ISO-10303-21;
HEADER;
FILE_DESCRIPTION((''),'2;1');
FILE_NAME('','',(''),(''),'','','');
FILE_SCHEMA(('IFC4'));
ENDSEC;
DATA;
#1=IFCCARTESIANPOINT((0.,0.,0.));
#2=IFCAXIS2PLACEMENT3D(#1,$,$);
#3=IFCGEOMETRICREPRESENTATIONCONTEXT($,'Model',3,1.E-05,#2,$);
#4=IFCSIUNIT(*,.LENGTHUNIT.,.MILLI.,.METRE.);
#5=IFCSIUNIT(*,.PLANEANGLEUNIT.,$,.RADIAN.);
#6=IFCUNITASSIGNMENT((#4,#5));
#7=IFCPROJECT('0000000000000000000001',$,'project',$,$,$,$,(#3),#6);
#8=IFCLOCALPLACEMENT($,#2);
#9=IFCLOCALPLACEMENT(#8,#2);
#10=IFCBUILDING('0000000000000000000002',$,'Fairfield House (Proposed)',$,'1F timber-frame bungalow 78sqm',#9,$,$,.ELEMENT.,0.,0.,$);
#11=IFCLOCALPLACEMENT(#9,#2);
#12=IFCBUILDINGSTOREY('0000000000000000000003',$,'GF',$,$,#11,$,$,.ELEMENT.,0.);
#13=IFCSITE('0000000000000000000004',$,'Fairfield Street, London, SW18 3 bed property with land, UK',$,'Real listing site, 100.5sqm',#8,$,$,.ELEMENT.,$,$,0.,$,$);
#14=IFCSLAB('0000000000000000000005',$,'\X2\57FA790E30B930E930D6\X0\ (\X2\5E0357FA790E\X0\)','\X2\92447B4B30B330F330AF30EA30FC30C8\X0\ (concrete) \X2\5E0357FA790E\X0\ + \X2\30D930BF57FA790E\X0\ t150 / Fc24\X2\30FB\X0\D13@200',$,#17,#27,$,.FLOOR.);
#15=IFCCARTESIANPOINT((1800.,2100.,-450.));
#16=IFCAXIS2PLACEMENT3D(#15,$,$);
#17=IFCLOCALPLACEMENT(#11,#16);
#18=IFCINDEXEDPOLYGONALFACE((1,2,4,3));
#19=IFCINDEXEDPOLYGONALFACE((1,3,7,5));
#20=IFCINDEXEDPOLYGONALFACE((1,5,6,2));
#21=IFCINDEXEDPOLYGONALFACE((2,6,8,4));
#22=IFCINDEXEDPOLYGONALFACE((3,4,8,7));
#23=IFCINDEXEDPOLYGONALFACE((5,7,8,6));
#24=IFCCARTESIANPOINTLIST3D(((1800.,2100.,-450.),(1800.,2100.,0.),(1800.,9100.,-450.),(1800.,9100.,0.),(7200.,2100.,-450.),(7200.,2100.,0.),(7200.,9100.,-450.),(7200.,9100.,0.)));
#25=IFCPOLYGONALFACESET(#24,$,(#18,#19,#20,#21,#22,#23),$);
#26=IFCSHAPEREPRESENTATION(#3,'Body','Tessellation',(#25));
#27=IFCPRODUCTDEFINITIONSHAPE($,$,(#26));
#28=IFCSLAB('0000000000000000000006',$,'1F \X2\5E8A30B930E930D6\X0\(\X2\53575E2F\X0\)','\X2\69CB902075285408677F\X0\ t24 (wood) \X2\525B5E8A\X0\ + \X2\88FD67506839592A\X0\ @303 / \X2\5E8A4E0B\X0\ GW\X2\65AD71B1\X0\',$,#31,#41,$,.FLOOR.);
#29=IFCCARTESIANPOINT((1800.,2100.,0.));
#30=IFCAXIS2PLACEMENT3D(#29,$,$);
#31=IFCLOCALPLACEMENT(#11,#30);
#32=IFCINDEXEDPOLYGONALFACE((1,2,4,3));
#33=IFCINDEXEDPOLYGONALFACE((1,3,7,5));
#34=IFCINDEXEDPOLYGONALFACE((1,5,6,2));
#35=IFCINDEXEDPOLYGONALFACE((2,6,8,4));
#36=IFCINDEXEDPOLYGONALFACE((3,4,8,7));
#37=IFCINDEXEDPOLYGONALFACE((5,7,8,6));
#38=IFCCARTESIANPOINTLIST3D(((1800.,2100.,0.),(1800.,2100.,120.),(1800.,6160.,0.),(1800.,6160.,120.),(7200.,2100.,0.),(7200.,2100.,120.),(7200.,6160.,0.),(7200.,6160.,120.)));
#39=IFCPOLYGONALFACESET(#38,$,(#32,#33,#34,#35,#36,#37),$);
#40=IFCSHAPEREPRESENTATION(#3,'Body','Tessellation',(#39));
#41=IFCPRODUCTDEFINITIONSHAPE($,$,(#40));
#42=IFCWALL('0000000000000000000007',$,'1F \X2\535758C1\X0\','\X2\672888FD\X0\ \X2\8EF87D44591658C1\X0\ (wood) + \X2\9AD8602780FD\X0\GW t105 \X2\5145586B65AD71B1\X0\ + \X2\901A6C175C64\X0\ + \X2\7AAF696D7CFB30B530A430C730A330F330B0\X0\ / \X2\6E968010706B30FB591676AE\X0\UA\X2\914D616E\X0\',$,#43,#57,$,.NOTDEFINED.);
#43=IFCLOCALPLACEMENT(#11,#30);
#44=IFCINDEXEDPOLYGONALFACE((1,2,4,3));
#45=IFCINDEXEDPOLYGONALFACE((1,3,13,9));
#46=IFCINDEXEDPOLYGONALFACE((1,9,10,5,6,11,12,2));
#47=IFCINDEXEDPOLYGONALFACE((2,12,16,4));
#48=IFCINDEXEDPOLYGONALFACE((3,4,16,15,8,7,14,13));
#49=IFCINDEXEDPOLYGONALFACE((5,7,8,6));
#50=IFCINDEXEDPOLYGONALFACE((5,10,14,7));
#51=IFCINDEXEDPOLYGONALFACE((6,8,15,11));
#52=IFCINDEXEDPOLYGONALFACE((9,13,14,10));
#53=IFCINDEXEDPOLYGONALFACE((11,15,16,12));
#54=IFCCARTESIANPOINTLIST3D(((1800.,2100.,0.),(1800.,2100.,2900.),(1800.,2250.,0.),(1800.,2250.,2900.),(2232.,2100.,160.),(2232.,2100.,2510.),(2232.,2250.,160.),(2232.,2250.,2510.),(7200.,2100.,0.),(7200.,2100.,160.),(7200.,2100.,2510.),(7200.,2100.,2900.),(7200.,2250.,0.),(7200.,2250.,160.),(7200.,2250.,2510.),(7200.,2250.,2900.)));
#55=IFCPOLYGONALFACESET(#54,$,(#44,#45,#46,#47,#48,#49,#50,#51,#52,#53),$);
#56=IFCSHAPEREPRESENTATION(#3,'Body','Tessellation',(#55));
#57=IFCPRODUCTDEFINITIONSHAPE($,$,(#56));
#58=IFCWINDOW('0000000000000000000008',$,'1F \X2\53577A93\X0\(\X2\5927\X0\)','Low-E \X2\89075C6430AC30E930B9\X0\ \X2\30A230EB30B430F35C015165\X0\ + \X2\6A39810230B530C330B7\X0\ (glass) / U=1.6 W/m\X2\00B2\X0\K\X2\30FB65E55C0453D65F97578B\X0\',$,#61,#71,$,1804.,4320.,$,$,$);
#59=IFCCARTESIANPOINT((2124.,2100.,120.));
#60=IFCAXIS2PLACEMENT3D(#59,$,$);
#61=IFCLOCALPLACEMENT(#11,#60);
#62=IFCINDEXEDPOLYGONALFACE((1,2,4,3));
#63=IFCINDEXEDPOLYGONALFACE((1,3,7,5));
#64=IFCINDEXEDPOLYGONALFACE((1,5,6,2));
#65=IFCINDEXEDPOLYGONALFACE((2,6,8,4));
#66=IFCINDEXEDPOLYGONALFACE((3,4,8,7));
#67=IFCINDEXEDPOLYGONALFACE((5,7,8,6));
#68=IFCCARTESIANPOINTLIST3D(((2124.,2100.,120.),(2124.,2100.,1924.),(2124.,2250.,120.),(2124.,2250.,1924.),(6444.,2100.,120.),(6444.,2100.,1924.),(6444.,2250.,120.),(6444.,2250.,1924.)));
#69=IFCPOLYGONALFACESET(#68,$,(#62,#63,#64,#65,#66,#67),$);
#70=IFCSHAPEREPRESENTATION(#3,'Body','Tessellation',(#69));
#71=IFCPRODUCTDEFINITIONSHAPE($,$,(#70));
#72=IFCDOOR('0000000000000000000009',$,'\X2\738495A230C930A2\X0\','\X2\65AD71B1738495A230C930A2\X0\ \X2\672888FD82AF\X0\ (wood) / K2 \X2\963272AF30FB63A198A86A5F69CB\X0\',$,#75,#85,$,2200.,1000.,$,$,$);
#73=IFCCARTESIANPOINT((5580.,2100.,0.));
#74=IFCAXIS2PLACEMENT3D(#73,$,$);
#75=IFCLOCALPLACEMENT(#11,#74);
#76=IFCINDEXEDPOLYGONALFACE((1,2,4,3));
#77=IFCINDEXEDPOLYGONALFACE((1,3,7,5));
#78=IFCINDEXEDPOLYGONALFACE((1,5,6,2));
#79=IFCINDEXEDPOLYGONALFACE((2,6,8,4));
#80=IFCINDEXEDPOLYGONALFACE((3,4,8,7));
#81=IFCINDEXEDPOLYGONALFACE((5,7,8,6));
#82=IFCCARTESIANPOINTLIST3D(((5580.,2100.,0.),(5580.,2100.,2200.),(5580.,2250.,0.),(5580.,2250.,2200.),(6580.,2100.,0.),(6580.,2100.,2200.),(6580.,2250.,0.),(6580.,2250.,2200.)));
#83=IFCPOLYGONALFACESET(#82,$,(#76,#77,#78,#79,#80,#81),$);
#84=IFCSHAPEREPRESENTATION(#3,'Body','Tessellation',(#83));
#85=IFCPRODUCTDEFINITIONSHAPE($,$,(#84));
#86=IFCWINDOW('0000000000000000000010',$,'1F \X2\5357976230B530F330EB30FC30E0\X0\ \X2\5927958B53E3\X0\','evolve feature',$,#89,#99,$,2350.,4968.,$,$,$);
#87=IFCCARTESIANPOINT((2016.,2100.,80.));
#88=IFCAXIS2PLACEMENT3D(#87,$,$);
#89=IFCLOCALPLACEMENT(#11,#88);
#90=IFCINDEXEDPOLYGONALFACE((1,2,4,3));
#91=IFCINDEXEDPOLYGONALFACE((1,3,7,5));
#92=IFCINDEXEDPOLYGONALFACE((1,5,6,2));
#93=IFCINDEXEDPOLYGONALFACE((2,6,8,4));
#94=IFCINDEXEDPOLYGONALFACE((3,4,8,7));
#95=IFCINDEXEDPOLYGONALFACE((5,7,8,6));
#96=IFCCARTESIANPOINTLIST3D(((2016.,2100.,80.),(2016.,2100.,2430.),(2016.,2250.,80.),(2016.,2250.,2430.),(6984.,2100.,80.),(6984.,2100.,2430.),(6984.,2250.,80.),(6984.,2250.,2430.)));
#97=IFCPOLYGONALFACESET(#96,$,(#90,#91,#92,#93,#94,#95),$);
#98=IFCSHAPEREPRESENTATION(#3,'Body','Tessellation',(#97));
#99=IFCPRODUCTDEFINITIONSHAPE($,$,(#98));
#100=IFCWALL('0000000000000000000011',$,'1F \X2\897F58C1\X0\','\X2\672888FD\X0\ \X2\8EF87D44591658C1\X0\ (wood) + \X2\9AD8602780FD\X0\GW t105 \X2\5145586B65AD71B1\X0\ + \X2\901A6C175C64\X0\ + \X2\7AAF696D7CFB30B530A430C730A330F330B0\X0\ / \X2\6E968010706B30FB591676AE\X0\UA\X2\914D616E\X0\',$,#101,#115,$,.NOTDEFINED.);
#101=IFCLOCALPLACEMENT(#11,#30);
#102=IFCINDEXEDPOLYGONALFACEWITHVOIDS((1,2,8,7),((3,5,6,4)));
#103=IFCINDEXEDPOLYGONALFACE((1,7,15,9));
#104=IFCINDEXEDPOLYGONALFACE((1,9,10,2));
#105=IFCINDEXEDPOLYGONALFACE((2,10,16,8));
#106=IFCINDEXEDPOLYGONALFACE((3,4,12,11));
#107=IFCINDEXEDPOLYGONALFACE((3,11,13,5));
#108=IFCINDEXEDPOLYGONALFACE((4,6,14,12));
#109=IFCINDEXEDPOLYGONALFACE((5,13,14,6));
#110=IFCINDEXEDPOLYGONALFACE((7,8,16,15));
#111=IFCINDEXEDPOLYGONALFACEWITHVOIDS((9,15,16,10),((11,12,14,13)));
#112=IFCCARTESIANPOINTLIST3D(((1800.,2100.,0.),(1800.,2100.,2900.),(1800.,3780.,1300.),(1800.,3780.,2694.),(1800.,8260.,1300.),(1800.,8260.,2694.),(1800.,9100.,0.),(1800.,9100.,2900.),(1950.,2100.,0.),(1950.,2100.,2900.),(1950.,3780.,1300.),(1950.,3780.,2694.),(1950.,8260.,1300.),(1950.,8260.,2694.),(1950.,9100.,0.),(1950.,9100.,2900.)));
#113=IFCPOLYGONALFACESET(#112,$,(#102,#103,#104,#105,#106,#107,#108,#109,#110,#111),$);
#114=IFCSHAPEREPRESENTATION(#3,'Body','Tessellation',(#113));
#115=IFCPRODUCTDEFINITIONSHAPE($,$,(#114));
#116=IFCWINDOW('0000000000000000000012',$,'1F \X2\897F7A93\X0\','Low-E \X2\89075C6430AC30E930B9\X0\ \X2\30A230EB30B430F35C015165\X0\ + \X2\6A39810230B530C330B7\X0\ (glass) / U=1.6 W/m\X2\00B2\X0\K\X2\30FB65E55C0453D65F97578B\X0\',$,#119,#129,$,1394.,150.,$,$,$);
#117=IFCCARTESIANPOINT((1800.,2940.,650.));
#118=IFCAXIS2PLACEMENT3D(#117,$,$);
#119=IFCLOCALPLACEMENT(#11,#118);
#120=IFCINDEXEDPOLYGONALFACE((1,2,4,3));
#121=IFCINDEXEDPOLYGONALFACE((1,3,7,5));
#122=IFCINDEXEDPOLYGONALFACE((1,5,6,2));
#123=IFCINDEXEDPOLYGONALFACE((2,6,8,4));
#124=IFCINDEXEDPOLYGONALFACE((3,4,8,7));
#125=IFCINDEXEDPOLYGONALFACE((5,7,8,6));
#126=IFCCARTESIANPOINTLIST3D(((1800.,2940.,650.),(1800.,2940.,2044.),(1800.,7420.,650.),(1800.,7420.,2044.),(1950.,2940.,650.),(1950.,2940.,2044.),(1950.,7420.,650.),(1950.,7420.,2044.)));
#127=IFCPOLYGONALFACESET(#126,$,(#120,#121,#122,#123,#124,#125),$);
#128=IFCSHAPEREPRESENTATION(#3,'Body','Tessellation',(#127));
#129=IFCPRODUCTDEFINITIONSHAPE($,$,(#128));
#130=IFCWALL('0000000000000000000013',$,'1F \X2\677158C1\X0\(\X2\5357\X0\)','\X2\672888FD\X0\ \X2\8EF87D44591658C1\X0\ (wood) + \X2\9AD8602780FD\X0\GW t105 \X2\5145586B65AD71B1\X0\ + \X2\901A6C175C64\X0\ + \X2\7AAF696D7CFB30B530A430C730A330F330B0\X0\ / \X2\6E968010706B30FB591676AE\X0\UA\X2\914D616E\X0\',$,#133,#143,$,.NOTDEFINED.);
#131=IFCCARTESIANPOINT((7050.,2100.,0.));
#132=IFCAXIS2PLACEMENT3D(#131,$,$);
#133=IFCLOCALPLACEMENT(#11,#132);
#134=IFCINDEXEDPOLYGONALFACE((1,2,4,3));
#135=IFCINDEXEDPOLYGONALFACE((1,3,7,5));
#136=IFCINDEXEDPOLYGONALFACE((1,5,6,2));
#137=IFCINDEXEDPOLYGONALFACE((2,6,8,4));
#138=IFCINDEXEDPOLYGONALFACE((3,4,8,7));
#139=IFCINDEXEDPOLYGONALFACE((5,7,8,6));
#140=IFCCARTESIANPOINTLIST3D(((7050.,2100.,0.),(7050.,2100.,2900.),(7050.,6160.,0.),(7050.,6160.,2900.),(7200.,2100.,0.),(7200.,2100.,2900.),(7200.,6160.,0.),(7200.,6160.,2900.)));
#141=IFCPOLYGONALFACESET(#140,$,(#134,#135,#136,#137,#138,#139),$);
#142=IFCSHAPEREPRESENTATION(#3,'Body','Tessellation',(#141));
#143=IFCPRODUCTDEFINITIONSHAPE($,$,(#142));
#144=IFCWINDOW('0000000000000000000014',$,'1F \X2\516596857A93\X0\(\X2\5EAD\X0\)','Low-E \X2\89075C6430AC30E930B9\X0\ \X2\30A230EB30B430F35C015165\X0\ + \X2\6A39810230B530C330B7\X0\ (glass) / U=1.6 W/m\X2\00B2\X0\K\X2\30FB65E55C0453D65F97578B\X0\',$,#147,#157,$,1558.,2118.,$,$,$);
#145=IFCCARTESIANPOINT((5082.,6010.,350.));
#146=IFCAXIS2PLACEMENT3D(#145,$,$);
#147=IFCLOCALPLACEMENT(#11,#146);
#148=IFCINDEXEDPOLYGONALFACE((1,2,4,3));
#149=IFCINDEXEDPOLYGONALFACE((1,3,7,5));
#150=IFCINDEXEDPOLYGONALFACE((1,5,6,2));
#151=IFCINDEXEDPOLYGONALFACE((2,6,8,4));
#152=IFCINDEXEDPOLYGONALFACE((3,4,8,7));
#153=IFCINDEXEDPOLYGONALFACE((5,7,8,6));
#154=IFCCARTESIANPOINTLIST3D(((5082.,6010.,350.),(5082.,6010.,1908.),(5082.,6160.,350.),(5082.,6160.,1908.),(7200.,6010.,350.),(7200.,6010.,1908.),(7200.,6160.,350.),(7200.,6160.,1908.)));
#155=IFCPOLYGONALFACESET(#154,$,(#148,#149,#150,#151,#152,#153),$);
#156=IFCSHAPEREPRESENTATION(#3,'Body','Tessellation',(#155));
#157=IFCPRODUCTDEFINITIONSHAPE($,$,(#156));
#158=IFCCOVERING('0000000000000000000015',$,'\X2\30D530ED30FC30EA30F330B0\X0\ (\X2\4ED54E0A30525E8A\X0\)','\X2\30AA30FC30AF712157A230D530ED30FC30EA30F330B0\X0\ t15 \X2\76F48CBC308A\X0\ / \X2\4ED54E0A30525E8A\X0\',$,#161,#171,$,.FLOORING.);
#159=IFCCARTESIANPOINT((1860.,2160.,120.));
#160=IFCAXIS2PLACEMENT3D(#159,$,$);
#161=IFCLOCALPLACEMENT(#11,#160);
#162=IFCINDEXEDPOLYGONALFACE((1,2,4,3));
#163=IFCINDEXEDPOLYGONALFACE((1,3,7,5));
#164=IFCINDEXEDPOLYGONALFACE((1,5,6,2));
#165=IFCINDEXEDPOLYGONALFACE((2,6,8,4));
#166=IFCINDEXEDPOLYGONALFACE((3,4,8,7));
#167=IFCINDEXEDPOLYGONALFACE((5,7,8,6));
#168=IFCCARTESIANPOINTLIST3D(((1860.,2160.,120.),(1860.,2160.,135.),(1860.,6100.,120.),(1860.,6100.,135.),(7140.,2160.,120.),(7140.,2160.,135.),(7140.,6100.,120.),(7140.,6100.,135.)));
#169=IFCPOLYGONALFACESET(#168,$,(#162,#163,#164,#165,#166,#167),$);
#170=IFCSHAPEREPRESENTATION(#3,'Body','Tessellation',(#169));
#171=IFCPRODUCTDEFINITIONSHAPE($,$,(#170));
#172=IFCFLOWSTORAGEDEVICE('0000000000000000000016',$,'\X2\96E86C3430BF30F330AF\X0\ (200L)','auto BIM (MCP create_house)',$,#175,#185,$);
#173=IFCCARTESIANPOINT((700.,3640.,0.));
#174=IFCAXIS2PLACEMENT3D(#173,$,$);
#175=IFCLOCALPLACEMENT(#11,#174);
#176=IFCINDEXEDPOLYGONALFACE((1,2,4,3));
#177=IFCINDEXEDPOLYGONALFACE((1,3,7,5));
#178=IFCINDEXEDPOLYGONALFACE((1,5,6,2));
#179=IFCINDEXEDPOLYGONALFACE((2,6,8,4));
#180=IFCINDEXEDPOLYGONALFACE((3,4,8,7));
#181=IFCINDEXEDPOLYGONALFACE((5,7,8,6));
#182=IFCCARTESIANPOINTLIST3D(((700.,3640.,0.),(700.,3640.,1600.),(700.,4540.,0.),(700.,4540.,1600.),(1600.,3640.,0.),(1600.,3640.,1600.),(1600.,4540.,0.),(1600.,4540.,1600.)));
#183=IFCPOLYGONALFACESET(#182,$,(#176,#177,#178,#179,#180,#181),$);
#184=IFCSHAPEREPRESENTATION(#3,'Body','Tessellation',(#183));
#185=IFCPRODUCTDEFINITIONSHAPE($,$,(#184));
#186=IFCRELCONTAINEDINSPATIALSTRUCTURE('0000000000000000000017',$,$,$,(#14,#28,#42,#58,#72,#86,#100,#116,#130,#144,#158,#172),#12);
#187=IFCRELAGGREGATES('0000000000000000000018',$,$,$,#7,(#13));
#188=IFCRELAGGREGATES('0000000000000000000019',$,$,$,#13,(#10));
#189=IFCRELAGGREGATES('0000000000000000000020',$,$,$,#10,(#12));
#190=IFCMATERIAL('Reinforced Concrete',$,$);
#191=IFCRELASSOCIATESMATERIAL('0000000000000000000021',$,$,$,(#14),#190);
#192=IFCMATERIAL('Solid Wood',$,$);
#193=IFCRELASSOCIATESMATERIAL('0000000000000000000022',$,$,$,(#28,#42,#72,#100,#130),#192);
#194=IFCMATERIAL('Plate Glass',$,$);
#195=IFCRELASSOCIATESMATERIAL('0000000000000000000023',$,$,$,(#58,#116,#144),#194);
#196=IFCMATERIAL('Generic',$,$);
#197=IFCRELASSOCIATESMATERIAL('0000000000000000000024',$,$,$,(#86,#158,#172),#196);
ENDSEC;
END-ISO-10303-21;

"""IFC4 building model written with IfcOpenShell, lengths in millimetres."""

from ifc_helpers import new_model, si_unit, frame, frame_2d, origin, place, context, project, spatial, rectangle, extrude, material, element, fill, save


model = new_model("IFC4")

# Units and contexts
model_context = context("Model", 3, precision=1e-05, world=origin())
ifc_project = project(units=[si_unit("LENGTHUNIT", "METRE", prefix="MILLI"), si_unit("PLANEANGLEUNIT", "RADIAN")], contexts=[model_context])

# Site, building, storey
site_placement = place(None, origin())
site = spatial("IfcSite", under=ifc_project, at=site_placement, Name="Fairfield Street, London, SW18 3 bed property with land, UK", ObjectType="Real listing site, 100.5sqm", CompositionType="ELEMENT", RefElevation=0.0)
building_placement = place(site_placement, origin())
building = spatial("IfcBuilding", under=site, at=building_placement, Name="Fairfield House (Proposed)", ObjectType="1F timber-frame bungalow 78sqm", CompositionType="ELEMENT", ElevationOfRefHeight=0.0, ElevationOfTerrain=0.0)
storey_placement = place(building_placement, origin())
storey = spatial("IfcBuildingStorey", under=building, at=storey_placement, Name="GF", CompositionType="ELEMENT", Elevation=0.0)

# Slabs
ifc_material_1 = material(Name="Reinforced Concrete")
slab_1_placement = place(storey_placement, frame((1800.0, 2100.0, -450.0)))
element("IfcSlab", 1, at=slab_1_placement, inside=storey, material=ifc_material_1, Name="基礎スラブ (布基礎)", Description="鉄筋コンクリート (concrete) 布基礎 + ベタ基礎 t150 / Fc24・D13@200", PredefinedType="FLOOR", context=model_context, shape_type="SweptSolid", body=[
    extrude(rectangle(XDim=5400.0, YDim=7000.0, at=frame_2d((2700.0, 3500.0))), frame((1800.0, 2100.0, -450.0)), (0.0, 0.0, 1.0), 450.0),
])
ifc_material_2 = material(Name="Solid Wood")
slab_2_placement = place(storey_placement, frame((1800.0, 2100.0, 0.0)))
element("IfcSlab", 2, at=slab_2_placement, inside=storey, material=ifc_material_2, Name="1F 床スラブ(南帯)", Description="構造用合板 t24 (wood) 剛床 + 製材根太 @303 / 床下 GW断熱", PredefinedType="FLOOR", context=model_context, shape_type="SweptSolid", body=[
    extrude(rectangle(XDim=5400.0, YDim=4060.0, at=frame_2d((2700.0, 2030.0))), frame((1800.0, 2100.0, 0.0)), (0.0, 0.0, 1.0), 120.0),
])

# Wall, openings, windows, door
wall_1_placement = place(storey_placement, frame((1800.0, 2100.0, 0.0)))
wall_1 = element("IfcWall", 3, at=wall_1_placement, inside=storey, material=ifc_material_2, Name="1F 南壁", Description="木製 軸組外壁 (wood) + 高性能GW t105 充填断熱 + 通気層 + 窯業系サイディング / 準耐火・外皮UA配慮", PredefinedType="NOTDEFINED", context=model_context, shape_type="SweptSolid", body=[
    extrude(rectangle(XDim=5400.0, YDim=150.0, at=frame_2d((2700.0, 75.0))), frame((1800.0, 2100.0, 0.0)), (0.0, 0.0, 1.0), 2900.0),
])
opening_1_placement = place(storey_placement, frame((2124.0, 2100.0, 120.0)))
opening_1 = element("IfcOpeningElement", 4, at=opening_1_placement, cuts=wall_1, PredefinedType="NOTDEFINED", context=model_context, shape_type="SweptSolid", body=[
    extrude(rectangle(XDim=4320.0, YDim=150.0, at=frame_2d((2160.0, 75.0))), frame((2124.0, 2100.0, 120.0)), (0.0, 0.0, 1.0), 1804.0),
])
opening_2_placement = place(storey_placement, frame((5580.0, 2100.0, 0.0)))
opening_2 = element("IfcOpeningElement", 5, at=opening_2_placement, cuts=wall_1, PredefinedType="NOTDEFINED", context=model_context, shape_type="SweptSolid", body=[
    extrude(rectangle(XDim=1000.0, YDim=150.0, at=frame_2d((500.0, 75.0))), frame((5580.0, 2100.0, 0.0)), (0.0, 0.0, 1.0), 2200.0),
])
opening_3_placement = place(storey_placement, frame((2016.0, 2100.0, 80.0)))
opening_3 = element("IfcOpeningElement", 6, at=opening_3_placement, cuts=wall_1, PredefinedType="NOTDEFINED", context=model_context, shape_type="SweptSolid", body=[
    extrude(rectangle(XDim=4968.0, YDim=150.0, at=frame_2d((2484.0, 75.0))), frame((2016.0, 2100.0, 80.0)), (0.0, 0.0, 1.0), 2350.0),
])
ifc_material_3 = material(Name="Plate Glass")
window_1_placement = place(storey_placement, frame((2124.0, 2100.0, 120.0)))
window_1 = element("IfcWindow", 7, at=window_1_placement, inside=storey, material=ifc_material_3, Name="1F 南窓(大)", Description="Low-E 複層ガラス アルゴン封入 + 樹脂サッシ (glass) / U=1.6 W/m²K・日射取得型", OverallHeight=1804.0, OverallWidth=4320.0, context=model_context, shape_type="SweptSolid", body=[
    extrude(rectangle(XDim=4320.0, YDim=150.0, at=frame_2d((2160.0, 75.0))), frame((2124.0, 2100.0, 120.0)), (0.0, 0.0, 1.0), 1804.0),
])
fill(opening_1, window_1)
door_1_placement = place(storey_placement, frame((5580.0, 2100.0, 0.0)))
door_1 = element("IfcDoor", 8, at=door_1_placement, inside=storey, material=ifc_material_2, Name="玄関ドア", Description="断熱玄関ドア 木製芯 (wood) / K2 防犯・採風機構", OverallHeight=2200.0, OverallWidth=1000.0, context=model_context, shape_type="SweptSolid", body=[
    extrude(rectangle(XDim=1000.0, YDim=150.0, at=frame_2d((500.0, 75.0))), frame((5580.0, 2100.0, 0.0)), (0.0, 0.0, 1.0), 2200.0),
])
fill(opening_2, door_1)
ifc_material_4 = material(Name="Generic")
window_2_placement = place(storey_placement, frame((2016.0, 2100.0, 80.0)))
window_2 = element("IfcWindow", 9, at=window_2_placement, inside=storey, material=ifc_material_4, Name="1F 南面サンルーム 大開口", Description="evolve feature", OverallHeight=2350.0, OverallWidth=4968.0, context=model_context, shape_type="SweptSolid", body=[
    extrude(rectangle(XDim=4968.0, YDim=150.0, at=frame_2d((2484.0, 75.0))), frame((2016.0, 2100.0, 80.0)), (0.0, 0.0, 1.0), 2350.0),
])
fill(opening_3, window_2)

# Walls, openings, windows
wall_2_placement = place(storey_placement, frame((1800.0, 2100.0, 0.0)))
wall_2 = element("IfcWall", 10, at=wall_2_placement, inside=storey, material=ifc_material_2, Name="1F 西壁", Description="木製 軸組外壁 (wood) + 高性能GW t105 充填断熱 + 通気層 + 窯業系サイディング / 準耐火・外皮UA配慮", PredefinedType="NOTDEFINED", context=model_context, shape_type="SweptSolid", body=[
    extrude(rectangle(XDim=150.0, YDim=7000.0, at=frame_2d((75.0, 3500.0))), frame((1800.0, 2100.0, 0.0)), (0.0, 0.0, 1.0), 2900.0),
])
opening_4_placement = place(storey_placement, frame((1800.0, 2940.0, 650.0)))
opening_4 = element("IfcOpeningElement", 11, at=opening_4_placement, cuts=wall_2, PredefinedType="NOTDEFINED", context=model_context, shape_type="SweptSolid", body=[
    extrude(rectangle(XDim=150.0, YDim=4480.0, at=frame_2d((75.0, 2240.0))), frame((1800.0, 2940.0, 650.0)), (0.0, 0.0, 1.0), 1394.0),
])
window_3_placement = place(storey_placement, frame((1800.0, 2940.0, 650.0)))
window_3 = element("IfcWindow", 12, at=window_3_placement, inside=storey, material=ifc_material_3, Name="1F 西窓", Description="Low-E 複層ガラス アルゴン封入 + 樹脂サッシ (glass) / U=1.6 W/m²K・日射取得型", OverallHeight=1394.0, OverallWidth=150.0, context=model_context, shape_type="SweptSolid", body=[
    extrude(rectangle(XDim=150.0, YDim=4480.0, at=frame_2d((75.0, 2240.0))), frame((1800.0, 2940.0, 650.0)), (0.0, 0.0, 1.0), 1394.0),
])
fill(opening_4, window_3)
wall_3_placement = place(storey_placement, frame((7050.0, 2100.0, 0.0)))
wall_3 = element("IfcWall", 13, at=wall_3_placement, inside=storey, material=ifc_material_2, Name="1F 東壁(南)", Description="木製 軸組外壁 (wood) + 高性能GW t105 充填断熱 + 通気層 + 窯業系サイディング / 準耐火・外皮UA配慮", PredefinedType="NOTDEFINED", context=model_context, shape_type="SweptSolid", body=[
    extrude(rectangle(XDim=150.0, YDim=4060.0, at=frame_2d((75.0, 2030.0))), frame((7050.0, 2100.0, 0.0)), (0.0, 0.0, 1.0), 2900.0),
])
opening_5_placement = place(storey_placement, frame((5082.0, 6010.0, 350.0)))
opening_5 = element("IfcOpeningElement", 14, at=opening_5_placement, cuts=wall_3, PredefinedType="NOTDEFINED", context=model_context, shape_type="SweptSolid", body=[
    extrude(rectangle(XDim=2118.0, YDim=150.0, at=frame_2d((1059.0, 75.0))), frame((5082.0, 6010.0, 350.0)), (0.0, 0.0, 1.0), 1558.0),
])
window_4_placement = place(storey_placement, frame((5082.0, 6010.0, 350.0)))
window_4 = element("IfcWindow", 15, at=window_4_placement, inside=storey, material=ifc_material_3, Name="1F 入隅窓(庭)", Description="Low-E 複層ガラス アルゴン封入 + 樹脂サッシ (glass) / U=1.6 W/m²K・日射取得型", OverallHeight=1558.0, OverallWidth=2118.0, context=model_context, shape_type="SweptSolid", body=[
    extrude(rectangle(XDim=2118.0, YDim=150.0, at=frame_2d((1059.0, 75.0))), frame((5082.0, 6010.0, 350.0)), (0.0, 0.0, 1.0), 1558.0),
])
fill(opening_5, window_4)

# Covering
covering_placement = place(storey_placement, frame((1860.0, 2160.0, 120.0)))
element("IfcCovering", 16, at=covering_placement, inside=storey, material=ifc_material_4, Name="フローリング (仕上げ床)", Description="オーク無垢フローリング t15 直貼り / 仕上げ床", PredefinedType="FLOORING", context=model_context, shape_type="SweptSolid", body=[
    extrude(rectangle(XDim=5280.0, YDim=3940.0, at=frame_2d((2640.0, 1970.0))), frame((1860.0, 2160.0, 120.0)), (0.0, 0.0, 1.0), 15.0),
])

# Flow storage device
flow_storage_device_placement = place(storey_placement, frame((700.0, 3640.0, 0.0)))
element("IfcFlowStorageDevice", 17, at=flow_storage_device_placement, inside=storey, material=ifc_material_4, Name="雨水タンク (200L)", Description="auto BIM (MCP create_house)", context=model_context, shape_type="SweptSolid", body=[
    extrude(rectangle(XDim=900.0, YDim=900.0, at=frame_2d((450.0, 450.0))), frame((700.0, 3640.0, 0.0)), (0.0, 0.0, 1.0), 1600.0),
])

save(model, "model.ifc")
